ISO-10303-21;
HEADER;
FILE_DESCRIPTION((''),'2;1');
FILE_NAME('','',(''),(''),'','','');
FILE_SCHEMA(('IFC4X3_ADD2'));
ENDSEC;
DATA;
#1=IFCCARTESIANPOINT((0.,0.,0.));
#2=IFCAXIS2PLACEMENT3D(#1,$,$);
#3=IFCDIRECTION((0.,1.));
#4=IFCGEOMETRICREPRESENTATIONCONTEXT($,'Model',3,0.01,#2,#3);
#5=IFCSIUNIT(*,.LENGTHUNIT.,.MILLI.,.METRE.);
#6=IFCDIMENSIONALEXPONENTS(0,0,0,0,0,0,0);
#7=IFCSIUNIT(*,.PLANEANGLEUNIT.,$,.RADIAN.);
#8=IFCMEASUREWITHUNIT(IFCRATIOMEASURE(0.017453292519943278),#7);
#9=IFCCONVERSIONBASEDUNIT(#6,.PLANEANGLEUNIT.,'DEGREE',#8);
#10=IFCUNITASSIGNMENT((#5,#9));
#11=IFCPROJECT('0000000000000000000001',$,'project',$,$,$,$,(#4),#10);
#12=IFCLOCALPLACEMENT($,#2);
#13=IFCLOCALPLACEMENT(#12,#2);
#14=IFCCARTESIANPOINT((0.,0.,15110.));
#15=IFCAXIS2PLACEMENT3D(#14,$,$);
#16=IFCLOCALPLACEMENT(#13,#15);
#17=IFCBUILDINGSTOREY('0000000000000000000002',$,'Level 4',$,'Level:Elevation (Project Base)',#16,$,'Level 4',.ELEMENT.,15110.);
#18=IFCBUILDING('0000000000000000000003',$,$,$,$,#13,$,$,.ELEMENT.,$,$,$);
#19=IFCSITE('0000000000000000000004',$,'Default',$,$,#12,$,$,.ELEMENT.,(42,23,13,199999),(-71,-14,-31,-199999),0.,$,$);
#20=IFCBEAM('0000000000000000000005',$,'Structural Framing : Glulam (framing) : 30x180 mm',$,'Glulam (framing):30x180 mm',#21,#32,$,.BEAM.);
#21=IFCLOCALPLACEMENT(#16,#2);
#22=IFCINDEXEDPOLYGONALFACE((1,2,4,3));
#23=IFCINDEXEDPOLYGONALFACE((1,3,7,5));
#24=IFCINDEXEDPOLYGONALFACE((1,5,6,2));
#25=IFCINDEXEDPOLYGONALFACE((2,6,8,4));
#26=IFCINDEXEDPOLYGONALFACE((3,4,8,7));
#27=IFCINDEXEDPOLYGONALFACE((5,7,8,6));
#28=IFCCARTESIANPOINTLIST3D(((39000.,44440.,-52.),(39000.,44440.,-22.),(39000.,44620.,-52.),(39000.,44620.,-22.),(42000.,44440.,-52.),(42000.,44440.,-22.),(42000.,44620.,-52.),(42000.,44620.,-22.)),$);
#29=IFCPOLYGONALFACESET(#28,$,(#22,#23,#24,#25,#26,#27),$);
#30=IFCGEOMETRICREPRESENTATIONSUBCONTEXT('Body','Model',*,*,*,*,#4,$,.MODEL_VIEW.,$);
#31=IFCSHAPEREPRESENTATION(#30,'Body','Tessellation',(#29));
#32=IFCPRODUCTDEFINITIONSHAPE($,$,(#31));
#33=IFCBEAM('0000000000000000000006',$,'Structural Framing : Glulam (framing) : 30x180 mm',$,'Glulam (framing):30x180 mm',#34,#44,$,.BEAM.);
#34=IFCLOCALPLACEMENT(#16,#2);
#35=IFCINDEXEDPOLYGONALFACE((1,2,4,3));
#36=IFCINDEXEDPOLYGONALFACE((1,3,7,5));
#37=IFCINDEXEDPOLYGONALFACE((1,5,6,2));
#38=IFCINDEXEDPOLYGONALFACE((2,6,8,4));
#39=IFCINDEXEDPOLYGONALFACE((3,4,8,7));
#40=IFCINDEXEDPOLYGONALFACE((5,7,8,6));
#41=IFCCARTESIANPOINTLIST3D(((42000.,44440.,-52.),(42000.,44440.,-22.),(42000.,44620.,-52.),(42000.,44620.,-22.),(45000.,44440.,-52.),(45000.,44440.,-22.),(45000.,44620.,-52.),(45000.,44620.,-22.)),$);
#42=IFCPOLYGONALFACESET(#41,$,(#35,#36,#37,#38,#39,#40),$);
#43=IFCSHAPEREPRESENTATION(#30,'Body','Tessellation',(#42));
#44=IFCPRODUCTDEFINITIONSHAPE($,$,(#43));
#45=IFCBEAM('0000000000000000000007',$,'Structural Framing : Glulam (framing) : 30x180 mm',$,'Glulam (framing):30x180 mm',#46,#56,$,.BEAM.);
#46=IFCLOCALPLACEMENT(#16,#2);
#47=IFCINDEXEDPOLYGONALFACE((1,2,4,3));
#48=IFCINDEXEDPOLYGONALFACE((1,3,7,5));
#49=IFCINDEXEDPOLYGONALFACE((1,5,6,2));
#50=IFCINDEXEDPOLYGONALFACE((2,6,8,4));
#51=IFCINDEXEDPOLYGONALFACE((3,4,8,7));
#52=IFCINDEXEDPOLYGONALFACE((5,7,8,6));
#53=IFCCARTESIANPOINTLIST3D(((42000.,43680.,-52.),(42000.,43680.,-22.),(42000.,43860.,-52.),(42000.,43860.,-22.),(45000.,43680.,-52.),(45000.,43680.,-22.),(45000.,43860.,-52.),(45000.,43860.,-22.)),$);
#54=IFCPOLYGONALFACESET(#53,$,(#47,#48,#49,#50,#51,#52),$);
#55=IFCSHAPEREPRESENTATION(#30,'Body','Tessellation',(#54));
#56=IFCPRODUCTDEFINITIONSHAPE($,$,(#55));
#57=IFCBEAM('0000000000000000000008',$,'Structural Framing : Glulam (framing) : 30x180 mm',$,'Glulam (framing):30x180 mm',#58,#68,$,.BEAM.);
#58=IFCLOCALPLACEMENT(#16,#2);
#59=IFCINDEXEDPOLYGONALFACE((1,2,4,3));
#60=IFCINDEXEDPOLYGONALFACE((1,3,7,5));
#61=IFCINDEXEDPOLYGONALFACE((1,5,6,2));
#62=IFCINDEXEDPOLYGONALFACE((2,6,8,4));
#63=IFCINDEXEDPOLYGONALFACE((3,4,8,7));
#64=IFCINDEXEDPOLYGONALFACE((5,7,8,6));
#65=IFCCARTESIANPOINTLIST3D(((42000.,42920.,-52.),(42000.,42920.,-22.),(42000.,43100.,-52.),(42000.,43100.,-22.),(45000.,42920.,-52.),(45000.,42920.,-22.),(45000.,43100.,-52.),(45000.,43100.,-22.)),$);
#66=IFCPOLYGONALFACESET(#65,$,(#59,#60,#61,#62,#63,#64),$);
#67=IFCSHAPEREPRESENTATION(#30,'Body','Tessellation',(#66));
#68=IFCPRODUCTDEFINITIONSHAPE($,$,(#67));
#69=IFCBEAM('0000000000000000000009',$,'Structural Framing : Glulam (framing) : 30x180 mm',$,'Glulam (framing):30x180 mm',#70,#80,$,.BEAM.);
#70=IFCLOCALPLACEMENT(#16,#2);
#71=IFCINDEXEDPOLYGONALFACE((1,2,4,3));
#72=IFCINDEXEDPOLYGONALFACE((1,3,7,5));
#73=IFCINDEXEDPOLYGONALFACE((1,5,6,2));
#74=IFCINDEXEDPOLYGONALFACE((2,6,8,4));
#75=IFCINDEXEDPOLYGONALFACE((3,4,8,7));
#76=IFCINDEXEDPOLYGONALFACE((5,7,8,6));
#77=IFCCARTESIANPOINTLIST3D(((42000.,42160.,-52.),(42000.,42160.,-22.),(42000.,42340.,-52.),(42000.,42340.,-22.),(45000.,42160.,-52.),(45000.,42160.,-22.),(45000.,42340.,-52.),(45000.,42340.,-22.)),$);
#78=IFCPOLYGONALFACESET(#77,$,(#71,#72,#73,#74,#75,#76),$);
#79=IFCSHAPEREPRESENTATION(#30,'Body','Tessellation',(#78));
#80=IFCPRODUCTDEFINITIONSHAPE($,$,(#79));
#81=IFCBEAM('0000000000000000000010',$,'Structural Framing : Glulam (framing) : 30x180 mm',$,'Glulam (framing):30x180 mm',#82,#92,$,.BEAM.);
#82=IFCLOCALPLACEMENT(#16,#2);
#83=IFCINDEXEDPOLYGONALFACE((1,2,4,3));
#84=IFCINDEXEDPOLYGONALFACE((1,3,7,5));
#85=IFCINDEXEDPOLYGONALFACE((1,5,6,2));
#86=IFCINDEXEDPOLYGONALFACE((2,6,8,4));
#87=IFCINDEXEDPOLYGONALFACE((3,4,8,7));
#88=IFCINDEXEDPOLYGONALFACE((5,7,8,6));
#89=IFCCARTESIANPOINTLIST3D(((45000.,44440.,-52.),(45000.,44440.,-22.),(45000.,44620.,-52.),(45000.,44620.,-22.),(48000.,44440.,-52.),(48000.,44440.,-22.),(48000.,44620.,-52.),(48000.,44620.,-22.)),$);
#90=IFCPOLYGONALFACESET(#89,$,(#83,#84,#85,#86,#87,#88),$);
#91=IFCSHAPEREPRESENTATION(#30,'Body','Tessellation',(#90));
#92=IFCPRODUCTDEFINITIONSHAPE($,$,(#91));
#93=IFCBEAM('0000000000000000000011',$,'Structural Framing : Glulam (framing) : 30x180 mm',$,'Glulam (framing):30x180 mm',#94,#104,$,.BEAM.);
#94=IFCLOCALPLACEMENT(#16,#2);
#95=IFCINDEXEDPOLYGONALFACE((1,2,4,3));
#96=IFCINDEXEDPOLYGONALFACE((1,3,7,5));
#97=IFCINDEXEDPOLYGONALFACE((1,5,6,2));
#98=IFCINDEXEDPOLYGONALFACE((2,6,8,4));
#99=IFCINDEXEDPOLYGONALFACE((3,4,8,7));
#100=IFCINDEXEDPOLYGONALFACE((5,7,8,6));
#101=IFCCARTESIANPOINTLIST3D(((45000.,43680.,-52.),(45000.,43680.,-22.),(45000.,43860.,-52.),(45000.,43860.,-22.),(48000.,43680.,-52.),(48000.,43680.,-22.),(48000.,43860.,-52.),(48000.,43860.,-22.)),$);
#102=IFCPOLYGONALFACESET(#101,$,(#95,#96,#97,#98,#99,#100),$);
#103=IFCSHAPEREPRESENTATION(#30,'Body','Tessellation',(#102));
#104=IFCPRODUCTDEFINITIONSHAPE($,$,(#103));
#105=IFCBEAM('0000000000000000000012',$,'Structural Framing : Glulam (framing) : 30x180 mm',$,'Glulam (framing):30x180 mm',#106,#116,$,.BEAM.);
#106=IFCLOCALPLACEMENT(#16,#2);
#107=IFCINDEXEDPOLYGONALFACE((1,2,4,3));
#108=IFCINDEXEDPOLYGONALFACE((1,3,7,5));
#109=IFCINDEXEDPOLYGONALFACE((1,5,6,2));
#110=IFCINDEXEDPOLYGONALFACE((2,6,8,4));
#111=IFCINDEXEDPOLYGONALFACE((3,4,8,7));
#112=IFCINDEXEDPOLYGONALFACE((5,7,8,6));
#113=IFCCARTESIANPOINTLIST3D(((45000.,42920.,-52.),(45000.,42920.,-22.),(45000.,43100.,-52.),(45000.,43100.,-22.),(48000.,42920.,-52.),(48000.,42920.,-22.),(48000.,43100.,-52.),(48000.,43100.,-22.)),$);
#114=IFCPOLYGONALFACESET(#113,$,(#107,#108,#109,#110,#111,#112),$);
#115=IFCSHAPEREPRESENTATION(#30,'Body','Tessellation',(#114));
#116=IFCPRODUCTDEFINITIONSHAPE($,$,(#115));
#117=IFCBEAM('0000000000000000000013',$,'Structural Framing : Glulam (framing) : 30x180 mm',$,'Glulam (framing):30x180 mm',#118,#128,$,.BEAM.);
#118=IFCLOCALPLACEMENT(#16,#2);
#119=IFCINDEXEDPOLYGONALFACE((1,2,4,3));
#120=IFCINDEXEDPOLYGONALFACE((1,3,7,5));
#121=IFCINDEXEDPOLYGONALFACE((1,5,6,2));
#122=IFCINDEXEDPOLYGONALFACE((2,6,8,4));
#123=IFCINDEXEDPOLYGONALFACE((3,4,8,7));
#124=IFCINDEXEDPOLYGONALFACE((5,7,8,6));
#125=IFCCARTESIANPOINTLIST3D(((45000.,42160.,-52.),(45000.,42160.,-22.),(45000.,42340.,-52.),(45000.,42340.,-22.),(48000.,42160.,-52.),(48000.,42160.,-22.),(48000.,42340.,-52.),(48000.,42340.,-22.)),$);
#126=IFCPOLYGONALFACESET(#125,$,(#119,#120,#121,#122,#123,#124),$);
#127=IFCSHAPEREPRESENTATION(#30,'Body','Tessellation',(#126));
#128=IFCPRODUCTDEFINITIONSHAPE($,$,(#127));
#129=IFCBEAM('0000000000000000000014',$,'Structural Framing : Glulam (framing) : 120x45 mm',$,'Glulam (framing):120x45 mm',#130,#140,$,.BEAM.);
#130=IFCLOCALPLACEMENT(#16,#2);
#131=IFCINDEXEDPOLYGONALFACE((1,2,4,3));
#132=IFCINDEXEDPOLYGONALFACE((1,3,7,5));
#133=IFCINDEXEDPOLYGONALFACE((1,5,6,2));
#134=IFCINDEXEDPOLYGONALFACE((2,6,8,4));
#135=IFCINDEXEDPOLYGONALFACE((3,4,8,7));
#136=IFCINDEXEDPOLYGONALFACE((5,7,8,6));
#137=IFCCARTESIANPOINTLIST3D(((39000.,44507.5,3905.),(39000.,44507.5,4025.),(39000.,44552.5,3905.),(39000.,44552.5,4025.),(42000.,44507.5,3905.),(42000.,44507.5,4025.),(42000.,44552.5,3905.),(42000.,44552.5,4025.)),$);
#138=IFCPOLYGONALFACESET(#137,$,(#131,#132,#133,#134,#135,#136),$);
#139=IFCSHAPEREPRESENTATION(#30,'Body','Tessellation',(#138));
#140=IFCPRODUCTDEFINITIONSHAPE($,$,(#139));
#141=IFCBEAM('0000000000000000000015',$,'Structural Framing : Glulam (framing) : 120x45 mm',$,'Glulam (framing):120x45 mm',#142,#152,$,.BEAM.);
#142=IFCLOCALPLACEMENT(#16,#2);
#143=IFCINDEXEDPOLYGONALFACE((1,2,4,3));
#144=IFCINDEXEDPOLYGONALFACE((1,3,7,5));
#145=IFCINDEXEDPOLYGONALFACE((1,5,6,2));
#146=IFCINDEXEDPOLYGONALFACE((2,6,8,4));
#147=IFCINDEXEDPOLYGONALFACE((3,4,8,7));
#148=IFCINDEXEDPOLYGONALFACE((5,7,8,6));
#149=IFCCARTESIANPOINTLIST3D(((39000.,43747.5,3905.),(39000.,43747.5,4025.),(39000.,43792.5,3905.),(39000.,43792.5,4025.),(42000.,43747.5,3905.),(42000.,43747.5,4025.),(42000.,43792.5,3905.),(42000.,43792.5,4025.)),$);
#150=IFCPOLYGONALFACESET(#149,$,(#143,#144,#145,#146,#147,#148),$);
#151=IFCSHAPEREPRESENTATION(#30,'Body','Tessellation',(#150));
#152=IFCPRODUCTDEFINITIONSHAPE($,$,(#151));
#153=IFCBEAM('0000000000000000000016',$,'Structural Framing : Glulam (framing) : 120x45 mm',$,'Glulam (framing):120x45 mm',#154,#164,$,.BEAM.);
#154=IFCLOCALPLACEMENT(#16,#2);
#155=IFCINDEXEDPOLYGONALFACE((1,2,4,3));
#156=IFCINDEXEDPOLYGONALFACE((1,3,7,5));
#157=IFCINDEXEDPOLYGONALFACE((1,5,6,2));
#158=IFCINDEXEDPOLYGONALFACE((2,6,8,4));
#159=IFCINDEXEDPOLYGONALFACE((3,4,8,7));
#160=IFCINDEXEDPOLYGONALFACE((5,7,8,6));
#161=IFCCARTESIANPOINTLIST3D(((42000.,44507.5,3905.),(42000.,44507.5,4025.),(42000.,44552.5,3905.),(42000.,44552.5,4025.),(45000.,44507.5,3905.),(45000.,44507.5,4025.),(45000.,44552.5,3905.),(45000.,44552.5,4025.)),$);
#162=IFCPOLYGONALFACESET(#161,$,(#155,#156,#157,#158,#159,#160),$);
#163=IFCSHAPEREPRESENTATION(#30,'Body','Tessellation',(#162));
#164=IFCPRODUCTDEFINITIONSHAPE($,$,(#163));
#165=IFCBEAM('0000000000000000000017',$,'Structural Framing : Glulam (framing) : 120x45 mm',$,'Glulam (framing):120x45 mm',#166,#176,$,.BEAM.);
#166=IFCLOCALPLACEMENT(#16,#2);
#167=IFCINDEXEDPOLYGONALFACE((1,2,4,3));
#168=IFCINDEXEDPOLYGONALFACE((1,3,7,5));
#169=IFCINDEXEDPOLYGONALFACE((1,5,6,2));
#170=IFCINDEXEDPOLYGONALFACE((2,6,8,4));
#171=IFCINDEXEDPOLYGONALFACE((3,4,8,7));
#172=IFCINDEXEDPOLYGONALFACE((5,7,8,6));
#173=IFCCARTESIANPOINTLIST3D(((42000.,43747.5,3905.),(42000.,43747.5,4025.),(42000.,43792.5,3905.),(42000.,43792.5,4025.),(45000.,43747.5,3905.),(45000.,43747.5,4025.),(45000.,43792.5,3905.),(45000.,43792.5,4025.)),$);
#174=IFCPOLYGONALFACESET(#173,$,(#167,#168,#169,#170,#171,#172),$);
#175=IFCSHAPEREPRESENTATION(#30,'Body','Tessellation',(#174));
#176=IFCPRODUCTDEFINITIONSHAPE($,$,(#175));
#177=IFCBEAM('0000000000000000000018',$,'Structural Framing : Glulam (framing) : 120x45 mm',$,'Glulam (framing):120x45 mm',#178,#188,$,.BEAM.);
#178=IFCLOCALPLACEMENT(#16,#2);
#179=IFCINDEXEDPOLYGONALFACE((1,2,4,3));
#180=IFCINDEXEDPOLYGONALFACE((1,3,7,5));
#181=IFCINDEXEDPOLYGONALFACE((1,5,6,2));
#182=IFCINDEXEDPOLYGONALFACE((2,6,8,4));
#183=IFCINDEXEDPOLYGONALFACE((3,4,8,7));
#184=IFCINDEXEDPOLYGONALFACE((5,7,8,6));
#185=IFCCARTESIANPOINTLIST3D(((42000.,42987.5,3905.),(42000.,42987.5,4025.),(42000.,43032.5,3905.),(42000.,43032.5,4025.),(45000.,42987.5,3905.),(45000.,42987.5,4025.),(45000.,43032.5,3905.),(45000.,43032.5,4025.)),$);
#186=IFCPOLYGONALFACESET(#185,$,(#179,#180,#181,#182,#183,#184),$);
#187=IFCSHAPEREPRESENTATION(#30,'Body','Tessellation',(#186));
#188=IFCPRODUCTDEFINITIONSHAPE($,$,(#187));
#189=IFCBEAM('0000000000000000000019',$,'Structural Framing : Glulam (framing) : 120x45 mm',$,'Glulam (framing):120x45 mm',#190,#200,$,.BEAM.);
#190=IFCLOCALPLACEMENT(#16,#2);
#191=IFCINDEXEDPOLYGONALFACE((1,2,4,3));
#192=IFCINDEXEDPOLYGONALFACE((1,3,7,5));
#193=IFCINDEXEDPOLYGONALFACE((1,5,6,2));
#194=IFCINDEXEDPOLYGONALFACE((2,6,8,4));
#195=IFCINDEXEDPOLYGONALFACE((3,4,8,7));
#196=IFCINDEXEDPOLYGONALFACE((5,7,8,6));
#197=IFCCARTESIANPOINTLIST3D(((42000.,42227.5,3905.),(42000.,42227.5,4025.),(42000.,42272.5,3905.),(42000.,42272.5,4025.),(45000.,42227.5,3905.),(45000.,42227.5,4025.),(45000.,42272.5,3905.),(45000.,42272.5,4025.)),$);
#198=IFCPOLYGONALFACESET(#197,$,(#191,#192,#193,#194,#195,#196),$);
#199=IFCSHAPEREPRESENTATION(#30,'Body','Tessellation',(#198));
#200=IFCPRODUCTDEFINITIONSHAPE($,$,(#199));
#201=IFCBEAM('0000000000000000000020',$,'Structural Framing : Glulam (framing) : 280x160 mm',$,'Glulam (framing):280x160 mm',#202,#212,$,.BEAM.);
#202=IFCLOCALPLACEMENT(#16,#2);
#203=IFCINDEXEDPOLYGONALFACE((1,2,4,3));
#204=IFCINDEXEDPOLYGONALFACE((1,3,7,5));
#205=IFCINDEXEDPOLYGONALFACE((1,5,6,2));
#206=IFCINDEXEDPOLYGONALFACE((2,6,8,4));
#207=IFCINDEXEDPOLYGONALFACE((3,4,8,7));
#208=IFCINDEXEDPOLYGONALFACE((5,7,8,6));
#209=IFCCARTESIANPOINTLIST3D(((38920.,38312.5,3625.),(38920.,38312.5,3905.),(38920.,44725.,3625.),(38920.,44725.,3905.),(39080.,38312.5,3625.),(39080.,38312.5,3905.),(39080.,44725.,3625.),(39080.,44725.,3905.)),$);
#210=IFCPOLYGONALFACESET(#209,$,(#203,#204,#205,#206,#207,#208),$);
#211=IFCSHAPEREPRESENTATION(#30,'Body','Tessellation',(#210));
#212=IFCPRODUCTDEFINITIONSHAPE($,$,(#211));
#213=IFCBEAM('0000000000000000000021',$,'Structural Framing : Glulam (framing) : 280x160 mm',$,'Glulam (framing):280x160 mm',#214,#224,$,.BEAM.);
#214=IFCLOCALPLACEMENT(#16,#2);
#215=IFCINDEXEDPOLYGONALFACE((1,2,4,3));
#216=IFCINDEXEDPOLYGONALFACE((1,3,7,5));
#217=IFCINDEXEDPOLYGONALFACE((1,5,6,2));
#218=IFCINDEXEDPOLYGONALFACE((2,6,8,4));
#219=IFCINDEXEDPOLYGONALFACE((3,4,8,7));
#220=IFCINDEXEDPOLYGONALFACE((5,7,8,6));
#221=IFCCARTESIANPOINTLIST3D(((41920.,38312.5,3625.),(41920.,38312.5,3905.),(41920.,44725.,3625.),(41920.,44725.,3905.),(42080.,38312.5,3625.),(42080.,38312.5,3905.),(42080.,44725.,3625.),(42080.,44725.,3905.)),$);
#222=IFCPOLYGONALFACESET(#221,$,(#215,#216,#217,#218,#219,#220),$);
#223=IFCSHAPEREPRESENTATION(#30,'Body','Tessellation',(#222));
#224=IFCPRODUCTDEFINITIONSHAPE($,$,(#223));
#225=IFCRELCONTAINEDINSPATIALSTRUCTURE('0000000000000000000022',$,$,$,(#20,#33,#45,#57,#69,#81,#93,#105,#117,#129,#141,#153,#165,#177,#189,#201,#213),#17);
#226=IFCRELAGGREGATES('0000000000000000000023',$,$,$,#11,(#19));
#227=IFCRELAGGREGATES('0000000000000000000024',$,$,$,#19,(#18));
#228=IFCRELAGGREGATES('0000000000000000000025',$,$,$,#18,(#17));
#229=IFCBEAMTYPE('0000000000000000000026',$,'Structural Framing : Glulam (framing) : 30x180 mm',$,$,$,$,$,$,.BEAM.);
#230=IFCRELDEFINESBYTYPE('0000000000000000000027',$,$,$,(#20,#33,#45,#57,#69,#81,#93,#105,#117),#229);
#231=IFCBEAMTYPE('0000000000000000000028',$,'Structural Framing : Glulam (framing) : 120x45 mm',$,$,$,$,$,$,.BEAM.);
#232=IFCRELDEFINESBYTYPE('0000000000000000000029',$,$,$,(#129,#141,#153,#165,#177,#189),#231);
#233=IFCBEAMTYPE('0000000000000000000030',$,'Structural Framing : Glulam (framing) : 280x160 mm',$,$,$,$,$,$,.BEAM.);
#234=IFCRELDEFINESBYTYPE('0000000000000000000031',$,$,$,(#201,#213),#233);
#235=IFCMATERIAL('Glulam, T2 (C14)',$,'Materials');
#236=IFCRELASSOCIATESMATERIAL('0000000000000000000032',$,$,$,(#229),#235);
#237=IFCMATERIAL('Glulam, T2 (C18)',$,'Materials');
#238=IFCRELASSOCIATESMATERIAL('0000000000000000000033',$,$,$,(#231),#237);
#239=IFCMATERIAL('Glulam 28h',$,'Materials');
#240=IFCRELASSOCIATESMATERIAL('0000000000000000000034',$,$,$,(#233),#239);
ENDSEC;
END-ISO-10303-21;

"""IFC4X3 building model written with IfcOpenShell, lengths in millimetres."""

from ifc_helpers import new_model, entity, si_unit, converted_unit, direction, frame, origin, origin_2d_with_axis, place, context, subcontext, project, spatial, rectangle, extrude, source, transform, mapped, material, material_profile, profile_set, type_object, type_shapes, element, save


model = new_model("IFC4X3")

# Units and contexts
model_context = context("Model", 3, precision=0.01, world=origin(), true_north=direction((0.0, 1.0)))
body_context = subcontext(model_context, "Body", "Model", "MODEL_VIEW")
ifc_project = project(units=[si_unit("LENGTHUNIT", "METRE", prefix="MILLI"), converted_unit("PLANEANGLEUNIT", "DEGREE", entity("IfcRatioMeasure", 0.017453292519943278), si_unit("PLANEANGLEUNIT", "RADIAN"), dimensions=[0, 0, 0, 0, 0, 0, 0])], contexts=[model_context])

# Site, building, storey
site_placement = place(None, origin())
site = spatial("IfcSite", under=ifc_project, at=site_placement, Name="Default", CompositionType="ELEMENT", RefLatitude=(42, 23, 13, 199999), RefLongitude=(-71, -14, -31, -199999), RefElevation=0.0)
building_placement = place(site_placement, origin())
building = spatial("IfcBuilding", under=site, at=building_placement, CompositionType="ELEMENT")
storey_placement = place(building_placement, frame((0.0, 0.0, 15110.0)))
storey = spatial("IfcBuildingStorey", under=building, at=storey_placement, Name="Level 4", ObjectType="Level:Elevation (Project Base)", LongName="Level 4", CompositionType="ELEMENT", Elevation=15110.0)

# Beams
ifc_material_1 = material(Name="Glulam, T2 (C14)", Category="Materials")
ifc_material_profile_1 = material_profile(ifc_material_1, rectangle(XDim=30.0, YDim=180.0, at=origin_2d_with_axis()), Name="30x180 mm")
ifc_profile_set_1 = profile_set([ifc_material_profile_1], Name="30x180 mm")
beam_type_1 = type_object("IfcBeamType", Name="Structural Framing : Glulam (framing) : 30x180 mm", PredefinedType="BEAM", material=ifc_profile_set_1)
shared_shape_1 = source(origin(), body_context, "Body", "SweptSolid", [
    extrude(rectangle(XDim=30.0, YDim=180.0, at=origin_2d_with_axis()), frame((500.0, 0.0, 0.0), z_axis=(1.0, 0.0, 0.0), x_axis=(0.0, 0.0, -1.0)), (0.0, 0.0, 1.0), 3000.0),
])
type_shapes(beam_type_1, [shared_shape_1])
for number, where, name in (
    (1, (38500.0, 44530.0, -37.0), "Structural Framing : Glulam (framing) : 30x180 mm"),
    (2, (41500.0, 44530.0, -37.0), "Structural Framing : Glulam (framing) : 30x180 mm"),
    (3, (41500.0, 43770.0, -37.0), "Structural Framing : Glulam (framing) : 30x180 mm"),
    (4, (41500.0, 43010.0, -37.0), "Structural Framing : Glulam (framing) : 30x180 mm"),
    (5, (41500.0, 42250.0, -37.0), "Structural Framing : Glulam (framing) : 30x180 mm"),
    (6, (44500.0, 44530.0, -37.0), "Structural Framing : Glulam (framing) : 30x180 mm"),
    (7, (44500.0, 43770.0, -37.0), "Structural Framing : Glulam (framing) : 30x180 mm"),
    (8, (44500.0, 43010.0, -37.0), "Structural Framing : Glulam (framing) : 30x180 mm"),
    (9, (44500.0, 42250.0, -37.0), "Structural Framing : Glulam (framing) : 30x180 mm"),
):
    element("IfcBeam", number, at=place(storey_placement, frame(where)), inside=storey, type_object=beam_type_1, Name=name, ObjectType="Glulam (framing):30x180 mm", PredefinedType="BEAM", context=body_context, shape_type="MappedRepresentation", body=[
        mapped(shared_shape_1, transform((0.0, 0.0, 0.0), scale=1.0)),
    ])
ifc_material_2 = material(Name="Glulam, T2 (C18)", Category="Materials")
ifc_material_profile_2 = material_profile(ifc_material_2, rectangle(XDim=120.0, YDim=45.0, at=origin_2d_with_axis()), Name="120x45 mm")
ifc_profile_set_2 = profile_set([ifc_material_profile_2], Name="120x45 mm")
beam_type_2 = type_object("IfcBeamType", Name="Structural Framing : Glulam (framing) : 120x45 mm", PredefinedType="BEAM", material=ifc_profile_set_2)
shared_shape_2 = source(origin(), body_context, "Body", "SweptSolid", [
    extrude(rectangle(XDim=120.0, YDim=45.0, at=origin_2d_with_axis()), frame((500.0, 0.0, 0.0), z_axis=(1.0, 0.0, 0.0), x_axis=(0.0, 0.0, -1.0)), (0.0, 0.0, 1.0), 3000.0),
])
type_shapes(beam_type_2, [shared_shape_2])
for number, where, name in (
    (10, (38500.0, 44530.0, 3965.0), "Structural Framing : Glulam (framing) : 120x45 mm"),
    (11, (38500.0, 43770.0, 3965.0), "Structural Framing : Glulam (framing) : 120x45 mm"),
    (12, (41500.0, 44530.0, 3965.0), "Structural Framing : Glulam (framing) : 120x45 mm"),
    (13, (41500.0, 43770.0, 3965.0), "Structural Framing : Glulam (framing) : 120x45 mm"),
    (14, (41500.0, 43010.0, 3965.0), "Structural Framing : Glulam (framing) : 120x45 mm"),
    (15, (41500.0, 42250.0, 3965.0), "Structural Framing : Glulam (framing) : 120x45 mm"),
):
    element("IfcBeam", number, at=place(storey_placement, frame(where)), inside=storey, type_object=beam_type_2, Name=name, ObjectType="Glulam (framing):120x45 mm", PredefinedType="BEAM", context=body_context, shape_type="MappedRepresentation", body=[
        mapped(shared_shape_2, transform((0.0, 0.0, 0.0), scale=1.0)),
    ])
ifc_material_3 = material(Name="Glulam 28h", Category="Materials")
ifc_material_profile_3 = material_profile(ifc_material_3, rectangle(XDim=280.0, YDim=160.0, at=origin_2d_with_axis()), Name="280x160 mm")
ifc_profile_set_3 = profile_set([ifc_material_profile_3], Name="280x160 mm")
beam_type_3 = type_object("IfcBeamType", Name="Structural Framing : Glulam (framing) : 280x160 mm", PredefinedType="BEAM", material=ifc_profile_set_3)
shared_shape_3 = source(origin(), body_context, "Body", "SweptSolid", [
    extrude(rectangle(XDim=280.0, YDim=160.0, at=origin_2d_with_axis()), frame((-2932.5, 0.0, 0.0), z_axis=(1.0, 0.0, 0.0), x_axis=(0.0, 0.0, -1.0)), (0.0, 0.0, 1.0), 6412.5),
])
type_shapes(beam_type_3, [shared_shape_3])
for number, where, z_axis, x_axis, name in (
    (16, (39000.0, 41792.5, 3765.0), (0.0, 0.0, 1.0), (0.0, -1.0, 0.0), "Structural Framing : Glulam (framing) : 280x160 mm"),
    (17, (42000.0, 41792.5, 3765.0), (0.0, 0.0, 1.0), (0.0, -1.0, 0.0), "Structural Framing : Glulam (framing) : 280x160 mm"),
):
    element("IfcBeam", number, at=place(storey_placement, frame(where, z_axis=z_axis, x_axis=x_axis)), inside=storey, type_object=beam_type_3, Name=name, ObjectType="Glulam (framing):280x160 mm", PredefinedType="BEAM", context=body_context, shape_type="MappedRepresentation", body=[
        mapped(shared_shape_3, transform((0.0, 0.0, 0.0), scale=1.0)),
    ])

save(model, "model.ifc")
